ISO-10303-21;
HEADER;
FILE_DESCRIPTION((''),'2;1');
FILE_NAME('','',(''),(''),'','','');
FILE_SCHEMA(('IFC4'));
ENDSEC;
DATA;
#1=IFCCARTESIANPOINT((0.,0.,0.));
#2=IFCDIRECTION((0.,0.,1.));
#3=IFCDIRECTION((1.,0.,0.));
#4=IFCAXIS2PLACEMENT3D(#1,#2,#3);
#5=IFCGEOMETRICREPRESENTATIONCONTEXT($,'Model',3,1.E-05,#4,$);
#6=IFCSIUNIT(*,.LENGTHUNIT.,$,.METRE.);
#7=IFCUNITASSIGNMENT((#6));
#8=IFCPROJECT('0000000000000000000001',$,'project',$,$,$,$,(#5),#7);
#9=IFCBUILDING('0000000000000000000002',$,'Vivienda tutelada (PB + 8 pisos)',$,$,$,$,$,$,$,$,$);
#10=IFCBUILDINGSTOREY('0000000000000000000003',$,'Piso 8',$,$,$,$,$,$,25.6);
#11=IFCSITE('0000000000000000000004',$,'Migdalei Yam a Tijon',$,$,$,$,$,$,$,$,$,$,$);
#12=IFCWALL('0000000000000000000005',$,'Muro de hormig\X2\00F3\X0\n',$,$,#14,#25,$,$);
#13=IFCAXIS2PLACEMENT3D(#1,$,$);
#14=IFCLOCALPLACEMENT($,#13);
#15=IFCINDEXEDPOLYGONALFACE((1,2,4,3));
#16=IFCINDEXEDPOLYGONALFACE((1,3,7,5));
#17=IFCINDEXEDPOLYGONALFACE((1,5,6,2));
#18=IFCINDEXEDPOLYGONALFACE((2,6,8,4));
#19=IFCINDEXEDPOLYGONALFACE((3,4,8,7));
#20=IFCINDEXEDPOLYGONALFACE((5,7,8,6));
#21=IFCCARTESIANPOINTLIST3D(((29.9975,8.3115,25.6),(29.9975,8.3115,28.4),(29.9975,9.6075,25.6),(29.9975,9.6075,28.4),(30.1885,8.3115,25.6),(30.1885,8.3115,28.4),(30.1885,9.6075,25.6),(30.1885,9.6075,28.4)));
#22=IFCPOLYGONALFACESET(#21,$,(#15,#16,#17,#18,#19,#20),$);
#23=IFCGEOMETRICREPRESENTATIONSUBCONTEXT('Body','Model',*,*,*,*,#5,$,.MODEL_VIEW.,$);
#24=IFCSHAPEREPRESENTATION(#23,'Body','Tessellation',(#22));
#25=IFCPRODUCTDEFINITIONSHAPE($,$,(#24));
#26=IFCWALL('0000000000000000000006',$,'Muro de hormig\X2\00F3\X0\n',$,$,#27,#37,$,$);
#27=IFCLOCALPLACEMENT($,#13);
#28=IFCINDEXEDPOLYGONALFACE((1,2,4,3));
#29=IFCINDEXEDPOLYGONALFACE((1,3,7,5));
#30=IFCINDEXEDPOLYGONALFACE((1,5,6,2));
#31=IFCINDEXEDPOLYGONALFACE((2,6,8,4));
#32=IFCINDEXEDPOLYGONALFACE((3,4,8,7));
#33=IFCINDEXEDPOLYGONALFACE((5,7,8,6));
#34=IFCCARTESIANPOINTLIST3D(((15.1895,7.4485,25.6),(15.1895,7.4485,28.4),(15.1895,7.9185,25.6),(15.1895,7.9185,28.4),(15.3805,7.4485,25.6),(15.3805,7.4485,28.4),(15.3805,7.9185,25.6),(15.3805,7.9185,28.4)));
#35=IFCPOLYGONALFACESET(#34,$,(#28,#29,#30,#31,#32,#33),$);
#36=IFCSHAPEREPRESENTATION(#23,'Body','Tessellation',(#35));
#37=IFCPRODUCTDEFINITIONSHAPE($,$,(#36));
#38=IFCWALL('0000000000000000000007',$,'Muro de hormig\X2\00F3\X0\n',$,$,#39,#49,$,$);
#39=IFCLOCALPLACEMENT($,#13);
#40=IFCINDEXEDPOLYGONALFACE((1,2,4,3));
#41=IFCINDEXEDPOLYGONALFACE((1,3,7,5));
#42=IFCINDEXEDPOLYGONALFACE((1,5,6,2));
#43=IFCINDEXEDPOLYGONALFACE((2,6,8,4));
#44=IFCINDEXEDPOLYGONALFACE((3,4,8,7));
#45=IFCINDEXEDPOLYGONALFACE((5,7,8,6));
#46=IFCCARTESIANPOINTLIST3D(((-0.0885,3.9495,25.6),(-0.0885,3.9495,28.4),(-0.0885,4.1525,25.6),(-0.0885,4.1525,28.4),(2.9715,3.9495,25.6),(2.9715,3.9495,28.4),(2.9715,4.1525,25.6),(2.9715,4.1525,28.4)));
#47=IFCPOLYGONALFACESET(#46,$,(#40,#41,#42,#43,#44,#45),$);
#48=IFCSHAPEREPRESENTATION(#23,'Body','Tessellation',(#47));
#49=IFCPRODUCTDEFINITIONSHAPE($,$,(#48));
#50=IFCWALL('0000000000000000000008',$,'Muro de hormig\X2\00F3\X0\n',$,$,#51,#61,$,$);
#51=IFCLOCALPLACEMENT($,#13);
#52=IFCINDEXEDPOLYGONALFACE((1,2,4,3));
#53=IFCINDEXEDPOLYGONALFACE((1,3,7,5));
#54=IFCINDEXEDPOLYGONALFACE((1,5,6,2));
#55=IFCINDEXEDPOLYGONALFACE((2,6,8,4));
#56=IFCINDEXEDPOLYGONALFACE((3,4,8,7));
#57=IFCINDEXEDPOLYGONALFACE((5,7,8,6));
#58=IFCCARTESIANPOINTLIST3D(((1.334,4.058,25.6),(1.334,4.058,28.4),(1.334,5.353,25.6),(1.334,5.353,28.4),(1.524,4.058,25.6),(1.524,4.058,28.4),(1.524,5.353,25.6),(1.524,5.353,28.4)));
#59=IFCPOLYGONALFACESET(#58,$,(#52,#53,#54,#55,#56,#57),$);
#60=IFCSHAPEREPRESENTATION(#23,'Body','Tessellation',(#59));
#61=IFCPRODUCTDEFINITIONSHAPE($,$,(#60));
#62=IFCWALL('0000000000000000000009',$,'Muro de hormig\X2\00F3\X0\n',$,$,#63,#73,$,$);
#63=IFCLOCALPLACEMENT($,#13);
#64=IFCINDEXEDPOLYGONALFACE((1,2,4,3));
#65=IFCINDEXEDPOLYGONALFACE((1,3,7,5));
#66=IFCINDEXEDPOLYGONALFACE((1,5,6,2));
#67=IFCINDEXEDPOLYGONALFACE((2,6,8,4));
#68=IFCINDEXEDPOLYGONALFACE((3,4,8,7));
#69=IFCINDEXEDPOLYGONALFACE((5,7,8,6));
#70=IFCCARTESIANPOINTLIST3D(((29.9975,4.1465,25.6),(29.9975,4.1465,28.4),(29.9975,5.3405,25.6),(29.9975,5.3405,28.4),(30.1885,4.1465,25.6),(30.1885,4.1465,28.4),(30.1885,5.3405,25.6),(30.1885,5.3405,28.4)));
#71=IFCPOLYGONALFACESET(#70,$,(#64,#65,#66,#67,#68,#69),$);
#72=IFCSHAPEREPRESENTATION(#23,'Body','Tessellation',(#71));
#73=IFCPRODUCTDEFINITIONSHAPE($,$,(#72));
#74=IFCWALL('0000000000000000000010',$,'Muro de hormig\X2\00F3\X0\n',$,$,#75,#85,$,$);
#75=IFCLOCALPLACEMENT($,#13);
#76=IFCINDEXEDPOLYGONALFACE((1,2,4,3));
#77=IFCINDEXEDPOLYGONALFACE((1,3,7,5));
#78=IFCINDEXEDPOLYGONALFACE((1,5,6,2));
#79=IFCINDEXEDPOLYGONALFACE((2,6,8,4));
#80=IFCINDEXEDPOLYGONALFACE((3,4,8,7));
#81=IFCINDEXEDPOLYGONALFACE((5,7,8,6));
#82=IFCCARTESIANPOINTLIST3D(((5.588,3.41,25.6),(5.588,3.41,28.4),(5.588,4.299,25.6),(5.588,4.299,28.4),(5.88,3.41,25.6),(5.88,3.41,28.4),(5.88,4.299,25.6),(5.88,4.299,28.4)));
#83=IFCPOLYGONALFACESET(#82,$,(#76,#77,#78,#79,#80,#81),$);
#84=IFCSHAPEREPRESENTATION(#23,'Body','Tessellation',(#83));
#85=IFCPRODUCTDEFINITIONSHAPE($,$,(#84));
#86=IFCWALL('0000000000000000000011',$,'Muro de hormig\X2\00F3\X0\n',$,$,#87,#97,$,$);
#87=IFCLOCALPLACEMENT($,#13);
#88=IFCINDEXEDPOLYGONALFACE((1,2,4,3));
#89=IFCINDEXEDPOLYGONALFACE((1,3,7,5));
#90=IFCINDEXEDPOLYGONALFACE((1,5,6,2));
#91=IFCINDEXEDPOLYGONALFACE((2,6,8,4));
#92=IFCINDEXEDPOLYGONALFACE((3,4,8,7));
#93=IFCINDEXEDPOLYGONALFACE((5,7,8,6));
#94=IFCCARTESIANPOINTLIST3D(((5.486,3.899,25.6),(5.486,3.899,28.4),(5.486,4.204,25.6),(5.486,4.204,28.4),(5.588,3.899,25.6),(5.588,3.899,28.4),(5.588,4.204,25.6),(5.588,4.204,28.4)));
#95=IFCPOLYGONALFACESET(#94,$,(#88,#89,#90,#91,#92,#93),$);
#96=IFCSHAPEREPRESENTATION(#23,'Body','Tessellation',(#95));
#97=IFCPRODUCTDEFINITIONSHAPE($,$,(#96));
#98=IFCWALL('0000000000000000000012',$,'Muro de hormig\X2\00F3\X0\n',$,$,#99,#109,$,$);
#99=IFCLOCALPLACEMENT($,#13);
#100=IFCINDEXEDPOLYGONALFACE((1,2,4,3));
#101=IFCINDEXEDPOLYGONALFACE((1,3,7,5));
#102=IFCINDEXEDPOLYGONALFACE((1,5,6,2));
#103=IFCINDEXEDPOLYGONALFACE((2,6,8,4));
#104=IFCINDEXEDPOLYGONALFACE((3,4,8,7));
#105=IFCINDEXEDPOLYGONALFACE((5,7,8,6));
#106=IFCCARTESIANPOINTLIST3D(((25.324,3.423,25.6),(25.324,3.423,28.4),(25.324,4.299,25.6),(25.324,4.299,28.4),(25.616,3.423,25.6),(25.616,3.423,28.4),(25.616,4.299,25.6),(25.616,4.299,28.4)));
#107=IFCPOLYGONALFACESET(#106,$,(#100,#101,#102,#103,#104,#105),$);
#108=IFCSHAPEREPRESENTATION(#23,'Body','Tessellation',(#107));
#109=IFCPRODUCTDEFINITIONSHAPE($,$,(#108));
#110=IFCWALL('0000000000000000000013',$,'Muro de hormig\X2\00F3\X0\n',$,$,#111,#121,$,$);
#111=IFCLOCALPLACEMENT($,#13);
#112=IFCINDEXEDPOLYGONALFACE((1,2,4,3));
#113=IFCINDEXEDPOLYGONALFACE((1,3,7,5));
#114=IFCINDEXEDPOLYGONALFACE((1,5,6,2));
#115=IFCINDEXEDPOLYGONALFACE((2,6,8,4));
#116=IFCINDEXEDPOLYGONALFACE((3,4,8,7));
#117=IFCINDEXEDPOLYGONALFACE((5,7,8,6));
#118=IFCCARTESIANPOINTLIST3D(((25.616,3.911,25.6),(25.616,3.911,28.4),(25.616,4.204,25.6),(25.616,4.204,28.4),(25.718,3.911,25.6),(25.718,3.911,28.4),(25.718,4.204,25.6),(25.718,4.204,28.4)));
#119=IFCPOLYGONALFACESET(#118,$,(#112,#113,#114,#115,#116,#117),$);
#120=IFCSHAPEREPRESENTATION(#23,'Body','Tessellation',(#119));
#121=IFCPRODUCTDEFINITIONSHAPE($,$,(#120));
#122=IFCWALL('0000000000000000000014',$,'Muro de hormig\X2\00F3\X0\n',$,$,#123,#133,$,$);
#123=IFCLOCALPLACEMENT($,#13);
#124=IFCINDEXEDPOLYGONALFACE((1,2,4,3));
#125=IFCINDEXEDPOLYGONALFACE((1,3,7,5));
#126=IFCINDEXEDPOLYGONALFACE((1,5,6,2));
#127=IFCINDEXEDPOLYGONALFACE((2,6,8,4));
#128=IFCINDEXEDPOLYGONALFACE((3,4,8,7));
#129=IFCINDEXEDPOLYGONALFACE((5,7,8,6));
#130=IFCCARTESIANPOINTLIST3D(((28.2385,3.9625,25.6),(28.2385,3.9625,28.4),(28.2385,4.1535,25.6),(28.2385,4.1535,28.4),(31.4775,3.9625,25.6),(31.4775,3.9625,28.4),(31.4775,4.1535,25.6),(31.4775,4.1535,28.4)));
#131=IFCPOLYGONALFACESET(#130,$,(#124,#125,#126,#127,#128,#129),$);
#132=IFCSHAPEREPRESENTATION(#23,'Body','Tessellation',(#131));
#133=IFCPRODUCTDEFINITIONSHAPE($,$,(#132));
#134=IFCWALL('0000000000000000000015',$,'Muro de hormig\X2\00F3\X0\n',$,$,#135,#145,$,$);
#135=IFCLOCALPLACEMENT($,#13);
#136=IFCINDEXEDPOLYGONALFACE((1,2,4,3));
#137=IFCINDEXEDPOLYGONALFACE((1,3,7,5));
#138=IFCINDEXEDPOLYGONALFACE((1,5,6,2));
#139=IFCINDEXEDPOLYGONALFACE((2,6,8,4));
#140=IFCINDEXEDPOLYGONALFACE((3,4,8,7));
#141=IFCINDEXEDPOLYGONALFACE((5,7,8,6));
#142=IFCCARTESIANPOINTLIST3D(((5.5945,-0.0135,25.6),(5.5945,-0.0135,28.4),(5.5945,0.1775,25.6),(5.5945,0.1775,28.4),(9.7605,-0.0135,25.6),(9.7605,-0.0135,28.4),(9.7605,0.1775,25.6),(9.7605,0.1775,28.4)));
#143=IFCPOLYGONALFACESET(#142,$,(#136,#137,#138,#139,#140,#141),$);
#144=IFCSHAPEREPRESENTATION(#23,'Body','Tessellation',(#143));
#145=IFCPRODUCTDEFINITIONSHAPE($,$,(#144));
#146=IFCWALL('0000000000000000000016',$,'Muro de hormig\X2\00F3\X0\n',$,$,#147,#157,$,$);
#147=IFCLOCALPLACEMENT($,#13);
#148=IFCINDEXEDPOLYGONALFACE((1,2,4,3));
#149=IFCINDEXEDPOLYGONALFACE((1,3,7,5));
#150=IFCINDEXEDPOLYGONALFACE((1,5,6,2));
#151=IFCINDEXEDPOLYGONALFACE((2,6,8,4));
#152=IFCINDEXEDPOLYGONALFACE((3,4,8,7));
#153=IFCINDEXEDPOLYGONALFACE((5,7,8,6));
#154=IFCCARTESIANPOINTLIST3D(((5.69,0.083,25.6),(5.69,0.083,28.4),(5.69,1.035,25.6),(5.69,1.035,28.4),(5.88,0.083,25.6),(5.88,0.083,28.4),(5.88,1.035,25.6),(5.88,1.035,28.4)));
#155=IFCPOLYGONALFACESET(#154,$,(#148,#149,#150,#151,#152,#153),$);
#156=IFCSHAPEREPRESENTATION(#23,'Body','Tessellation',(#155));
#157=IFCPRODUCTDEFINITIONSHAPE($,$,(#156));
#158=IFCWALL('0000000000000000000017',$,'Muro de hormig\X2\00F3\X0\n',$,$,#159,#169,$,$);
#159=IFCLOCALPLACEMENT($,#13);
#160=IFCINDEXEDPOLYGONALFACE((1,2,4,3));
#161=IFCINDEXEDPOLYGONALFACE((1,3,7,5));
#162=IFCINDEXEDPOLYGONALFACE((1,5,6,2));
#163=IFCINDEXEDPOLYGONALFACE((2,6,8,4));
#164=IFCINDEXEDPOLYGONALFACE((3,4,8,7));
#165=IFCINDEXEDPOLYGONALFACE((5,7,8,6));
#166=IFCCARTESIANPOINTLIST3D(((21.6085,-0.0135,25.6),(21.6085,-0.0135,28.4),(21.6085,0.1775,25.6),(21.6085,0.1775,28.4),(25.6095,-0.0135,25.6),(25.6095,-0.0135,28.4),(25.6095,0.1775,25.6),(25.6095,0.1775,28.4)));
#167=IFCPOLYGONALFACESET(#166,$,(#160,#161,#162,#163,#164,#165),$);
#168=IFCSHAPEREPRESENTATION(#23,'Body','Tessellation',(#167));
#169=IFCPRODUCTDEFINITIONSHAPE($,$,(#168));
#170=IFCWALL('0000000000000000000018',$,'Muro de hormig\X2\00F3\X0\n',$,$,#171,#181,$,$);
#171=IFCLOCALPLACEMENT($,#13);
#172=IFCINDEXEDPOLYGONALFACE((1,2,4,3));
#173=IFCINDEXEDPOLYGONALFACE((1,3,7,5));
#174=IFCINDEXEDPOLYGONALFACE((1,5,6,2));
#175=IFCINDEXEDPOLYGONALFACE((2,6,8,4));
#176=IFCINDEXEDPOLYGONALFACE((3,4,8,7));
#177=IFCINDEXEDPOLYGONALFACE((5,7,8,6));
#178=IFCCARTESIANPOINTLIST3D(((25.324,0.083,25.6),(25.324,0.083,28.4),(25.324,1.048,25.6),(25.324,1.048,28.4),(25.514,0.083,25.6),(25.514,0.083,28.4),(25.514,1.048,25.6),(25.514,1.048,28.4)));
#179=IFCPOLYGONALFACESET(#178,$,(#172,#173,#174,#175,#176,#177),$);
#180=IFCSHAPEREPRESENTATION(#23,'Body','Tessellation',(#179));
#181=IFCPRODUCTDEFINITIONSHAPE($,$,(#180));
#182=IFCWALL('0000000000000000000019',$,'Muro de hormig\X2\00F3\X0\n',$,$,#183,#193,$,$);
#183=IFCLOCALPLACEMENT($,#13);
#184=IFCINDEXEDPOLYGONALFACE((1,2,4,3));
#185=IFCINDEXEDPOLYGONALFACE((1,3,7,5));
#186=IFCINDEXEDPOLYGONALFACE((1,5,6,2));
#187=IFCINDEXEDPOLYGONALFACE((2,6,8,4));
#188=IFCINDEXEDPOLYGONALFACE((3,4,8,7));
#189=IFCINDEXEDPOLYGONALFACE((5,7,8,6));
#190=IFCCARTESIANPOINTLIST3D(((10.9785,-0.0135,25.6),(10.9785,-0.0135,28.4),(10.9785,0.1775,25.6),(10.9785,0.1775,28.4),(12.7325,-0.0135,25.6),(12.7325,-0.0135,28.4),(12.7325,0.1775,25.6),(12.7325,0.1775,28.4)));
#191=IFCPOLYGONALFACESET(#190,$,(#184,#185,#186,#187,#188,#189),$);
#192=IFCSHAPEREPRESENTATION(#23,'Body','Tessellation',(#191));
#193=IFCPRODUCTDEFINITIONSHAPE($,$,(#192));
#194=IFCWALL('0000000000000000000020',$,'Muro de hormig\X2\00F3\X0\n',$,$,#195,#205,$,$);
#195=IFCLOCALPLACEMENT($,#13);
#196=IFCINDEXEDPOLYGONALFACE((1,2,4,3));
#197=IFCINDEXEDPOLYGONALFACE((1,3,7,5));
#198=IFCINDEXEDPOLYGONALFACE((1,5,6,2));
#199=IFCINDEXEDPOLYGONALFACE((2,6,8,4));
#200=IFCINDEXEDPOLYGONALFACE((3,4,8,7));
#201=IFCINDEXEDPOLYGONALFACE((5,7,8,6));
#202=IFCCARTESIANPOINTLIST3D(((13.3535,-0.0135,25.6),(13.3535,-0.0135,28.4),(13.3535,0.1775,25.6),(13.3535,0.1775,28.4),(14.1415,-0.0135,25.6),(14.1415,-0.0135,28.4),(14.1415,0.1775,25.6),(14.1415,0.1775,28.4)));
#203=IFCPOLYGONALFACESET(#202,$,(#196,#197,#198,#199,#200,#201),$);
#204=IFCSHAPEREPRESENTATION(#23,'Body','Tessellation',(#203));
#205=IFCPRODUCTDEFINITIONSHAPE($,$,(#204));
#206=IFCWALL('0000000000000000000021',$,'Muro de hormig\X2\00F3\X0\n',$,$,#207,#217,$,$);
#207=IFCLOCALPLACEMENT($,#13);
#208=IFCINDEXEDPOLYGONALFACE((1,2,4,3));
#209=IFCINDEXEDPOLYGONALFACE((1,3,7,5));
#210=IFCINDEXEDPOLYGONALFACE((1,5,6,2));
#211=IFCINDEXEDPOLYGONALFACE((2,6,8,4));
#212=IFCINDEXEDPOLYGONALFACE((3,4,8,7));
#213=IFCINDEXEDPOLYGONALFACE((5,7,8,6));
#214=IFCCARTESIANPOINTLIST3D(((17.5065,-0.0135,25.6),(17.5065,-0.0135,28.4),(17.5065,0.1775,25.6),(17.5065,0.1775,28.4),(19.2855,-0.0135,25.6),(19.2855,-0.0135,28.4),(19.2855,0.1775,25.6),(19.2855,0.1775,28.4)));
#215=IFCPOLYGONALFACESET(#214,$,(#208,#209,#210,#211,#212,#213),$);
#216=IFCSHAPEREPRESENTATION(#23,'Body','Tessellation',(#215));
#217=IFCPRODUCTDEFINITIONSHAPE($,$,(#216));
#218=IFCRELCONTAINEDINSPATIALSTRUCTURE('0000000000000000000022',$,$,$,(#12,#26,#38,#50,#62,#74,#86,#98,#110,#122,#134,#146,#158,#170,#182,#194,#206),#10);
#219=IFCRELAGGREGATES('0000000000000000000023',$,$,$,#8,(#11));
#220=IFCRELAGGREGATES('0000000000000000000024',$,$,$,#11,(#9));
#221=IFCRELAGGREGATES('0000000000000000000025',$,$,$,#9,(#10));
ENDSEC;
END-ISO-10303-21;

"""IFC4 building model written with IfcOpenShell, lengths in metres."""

from ifc_helpers import new_model, si_unit, frame, origin_with_axes, context, subcontext, project, spatial, line, indexed_curve, outline, extrude, element, save


model = new_model("IFC4")

# Units and contexts
model_context = context("Model", 3, precision=1e-05, world=origin_with_axes())
body_context = subcontext(model_context, "Body", "Model", "MODEL_VIEW")
ifc_project = project(units=[si_unit("LENGTHUNIT", "METRE")], contexts=[model_context])

# Site, building, storey
site = spatial("IfcSite", under=ifc_project, Name="Migdalei Yam a Tijon")
building = spatial("IfcBuilding", under=site, Name="Vivienda tutelada (PB + 8 pisos)")
storey = spatial("IfcBuildingStorey", under=building, Name="Piso 8", Elevation=25.6)

# Walls
element("IfcWall", 1, inside=storey, Name="Muro de hormigón", context=body_context, shape_type="SweptSolid", body=[
    extrude(outline(indexed_curve([(0.0, 0.0), (0.191, 0.0), (0.191, 1.296), (0.0, 1.296)], segments=[line(1, 2, 3, 4, 1)])), frame((29.9975, 8.3115, 25.6), z_axis=(0.0, 0.0, 1.0), x_axis=(1.0, 0.0, 0.0)), (0.0, 0.0, 1.0), 2.8),
])
element("IfcWall", 2, inside=storey, Name="Muro de hormigón", context=body_context, shape_type="SweptSolid", body=[
    extrude(outline(indexed_curve([(0.0, 0.0), (0.191, 0.0), (0.191, 0.47), (0.0, 0.47)], segments=[line(1, 2, 3, 4, 1)])), frame((15.1895, 7.4485, 25.6), z_axis=(0.0, 0.0, 1.0), x_axis=(1.0, 0.0, 0.0)), (0.0, 0.0, 1.0), 2.8),
])
element("IfcWall", 3, inside=storey, Name="Muro de hormigón", context=body_context, shape_type="SweptSolid", body=[
    extrude(outline(indexed_curve([(0.0, 0.0), (3.06, 0.0), (3.06, 0.203), (0.0, 0.203)], segments=[line(1, 2, 3, 4, 1)])), frame((-0.0885, 3.9495, 25.6), z_axis=(0.0, 0.0, 1.0), x_axis=(1.0, 0.0, 0.0)), (0.0, 0.0, 1.0), 2.8),
])
element("IfcWall", 4, inside=storey, Name="Muro de hormigón", context=body_context, shape_type="SweptSolid", body=[
    extrude(outline(indexed_curve([(0.0, 0.0), (0.19, 0.0), (0.19, 1.295), (0.0, 1.295)], segments=[line(1, 2, 3, 4, 1)])), frame((1.334, 4.058, 25.6), z_axis=(0.0, 0.0, 1.0), x_axis=(1.0, 0.0, 0.0)), (0.0, 0.0, 1.0), 2.8),
])
element("IfcWall", 5, inside=storey, Name="Muro de hormigón", context=body_context, shape_type="SweptSolid", body=[
    extrude(outline(indexed_curve([(0.0, 0.0), (0.191, 0.0), (0.191, 1.194), (0.0, 1.194)], segments=[line(1, 2, 3, 4, 1)])), frame((29.9975, 4.1465, 25.6), z_axis=(0.0, 0.0, 1.0), x_axis=(1.0, 0.0, 0.0)), (0.0, 0.0, 1.0), 2.8),
])
element("IfcWall", 6, inside=storey, Name="Muro de hormigón", context=body_context, shape_type="SweptSolid", body=[
    extrude(outline(indexed_curve([(0.0, 0.0), (0.292, 0.0), (0.292, 0.889), (0.0, 0.889)], segments=[line(1, 2, 3, 4, 1)])), frame((5.588, 3.41, 25.6), z_axis=(0.0, 0.0, 1.0), x_axis=(1.0, 0.0, 0.0)), (0.0, 0.0, 1.0), 2.8),
])
element("IfcWall", 7, inside=storey, Name="Muro de hormigón", context=body_context, shape_type="SweptSolid", body=[
    extrude(outline(indexed_curve([(0.0, 0.0), (0.102, 0.0), (0.102, 0.305), (0.0, 0.305)], segments=[line(1, 2, 3, 4, 1)])), frame((5.486, 3.899, 25.6), z_axis=(0.0, 0.0, 1.0), x_axis=(1.0, 0.0, 0.0)), (0.0, 0.0, 1.0), 2.8),
])
element("IfcWall", 8, inside=storey, Name="Muro de hormigón", context=body_context, shape_type="SweptSolid", body=[
    extrude(outline(indexed_curve([(0.0, 0.0), (0.292, 0.0), (0.292, 0.876), (0.0, 0.876)], segments=[line(1, 2, 3, 4, 1)])), frame((25.324, 3.423, 25.6), z_axis=(0.0, 0.0, 1.0), x_axis=(1.0, 0.0, 0.0)), (0.0, 0.0, 1.0), 2.8),
])
element("IfcWall", 9, inside=storey, Name="Muro de hormigón", context=body_context, shape_type="SweptSolid", body=[
    extrude(outline(indexed_curve([(0.0, 0.0), (0.102, 0.0), (0.102, 0.293), (0.0, 0.293)], segments=[line(1, 2, 3, 4, 1)])), frame((25.616, 3.911, 25.6), z_axis=(0.0, 0.0, 1.0), x_axis=(1.0, 0.0, 0.0)), (0.0, 0.0, 1.0), 2.8),
])
element("IfcWall", 10, inside=storey, Name="Muro de hormigón", context=body_context, shape_type="SweptSolid", body=[
    extrude(outline(indexed_curve([(0.0, 0.0), (3.239, 0.0), (3.239, 0.191), (0.0, 0.191)], segments=[line(1, 2, 3, 4, 1)])), frame((28.2385, 3.9625, 25.6), z_axis=(0.0, 0.0, 1.0), x_axis=(1.0, 0.0, 0.0)), (0.0, 0.0, 1.0), 2.8),
])
element("IfcWall", 11, inside=storey, Name="Muro de hormigón", context=body_context, shape_type="SweptSolid", body=[
    extrude(outline(indexed_curve([(0.0, 0.0), (4.166, 0.0), (4.166, 0.191), (0.0, 0.191)], segments=[line(1, 2, 3, 4, 1)])), frame((5.5945, -0.0135, 25.6), z_axis=(0.0, 0.0, 1.0), x_axis=(1.0, 0.0, 0.0)), (0.0, 0.0, 1.0), 2.8),
])
element("IfcWall", 12, inside=storey, Name="Muro de hormigón", context=body_context, shape_type="SweptSolid", body=[
    extrude(outline(indexed_curve([(0.0, 0.0), (0.19, 0.0), (0.19, 0.952), (0.0, 0.952)], segments=[line(1, 2, 3, 4, 1)])), frame((5.69, 0.083, 25.6), z_axis=(0.0, 0.0, 1.0), x_axis=(1.0, 0.0, 0.0)), (0.0, 0.0, 1.0), 2.8),
])
element("IfcWall", 13, inside=storey, Name="Muro de hormigón", context=body_context, shape_type="SweptSolid", body=[
    extrude(outline(indexed_curve([(0.0, 0.0), (4.001, 0.0), (4.001, 0.191), (0.0, 0.191)], segments=[line(1, 2, 3, 4, 1)])), frame((21.6085, -0.0135, 25.6), z_axis=(0.0, 0.0, 1.0), x_axis=(1.0, 0.0, 0.0)), (0.0, 0.0, 1.0), 2.8),
])
element("IfcWall", 14, inside=storey, Name="Muro de hormigón", context=body_context, shape_type="SweptSolid", body=[
    extrude(outline(indexed_curve([(0.0, 0.0), (0.19, 0.0), (0.19, 0.965), (0.0, 0.965)], segments=[line(1, 2, 3, 4, 1)])), frame((25.324, 0.083, 25.6), z_axis=(0.0, 0.0, 1.0), x_axis=(1.0, 0.0, 0.0)), (0.0, 0.0, 1.0), 2.8),
])
element("IfcWall", 15, inside=storey, Name="Muro de hormigón", context=body_context, shape_type="SweptSolid", body=[
    extrude(outline(indexed_curve([(0.0, 0.0), (1.754, 0.0), (1.754, 0.191), (0.0, 0.191)], segments=[line(1, 2, 3, 4, 1)])), frame((10.9785, -0.0135, 25.6), z_axis=(0.0, 0.0, 1.0), x_axis=(1.0, 0.0, 0.0)), (0.0, 0.0, 1.0), 2.8),
])
element("IfcWall", 16, inside=storey, Name="Muro de hormigón", context=body_context, shape_type="SweptSolid", body=[
    extrude(outline(indexed_curve([(0.0, 0.0), (0.788, 0.0), (0.788, 0.191), (0.0, 0.191)], segments=[line(1, 2, 3, 4, 1)])), frame((13.3535, -0.0135, 25.6), z_axis=(0.0, 0.0, 1.0), x_axis=(1.0, 0.0, 0.0)), (0.0, 0.0, 1.0), 2.8),
])
element("IfcWall", 17, inside=storey, Name="Muro de hormigón", context=body_context, shape_type="SweptSolid", body=[
    extrude(outline(indexed_curve([(0.0, 0.0), (1.779, 0.0), (1.779, 0.191), (0.0, 0.191)], segments=[line(1, 2, 3, 4, 1)])), frame((17.5065, -0.0135, 25.6), z_axis=(0.0, 0.0, 1.0), x_axis=(1.0, 0.0, 0.0)), (0.0, 0.0, 1.0), 2.8),
])

save(model, "model.ifc")
